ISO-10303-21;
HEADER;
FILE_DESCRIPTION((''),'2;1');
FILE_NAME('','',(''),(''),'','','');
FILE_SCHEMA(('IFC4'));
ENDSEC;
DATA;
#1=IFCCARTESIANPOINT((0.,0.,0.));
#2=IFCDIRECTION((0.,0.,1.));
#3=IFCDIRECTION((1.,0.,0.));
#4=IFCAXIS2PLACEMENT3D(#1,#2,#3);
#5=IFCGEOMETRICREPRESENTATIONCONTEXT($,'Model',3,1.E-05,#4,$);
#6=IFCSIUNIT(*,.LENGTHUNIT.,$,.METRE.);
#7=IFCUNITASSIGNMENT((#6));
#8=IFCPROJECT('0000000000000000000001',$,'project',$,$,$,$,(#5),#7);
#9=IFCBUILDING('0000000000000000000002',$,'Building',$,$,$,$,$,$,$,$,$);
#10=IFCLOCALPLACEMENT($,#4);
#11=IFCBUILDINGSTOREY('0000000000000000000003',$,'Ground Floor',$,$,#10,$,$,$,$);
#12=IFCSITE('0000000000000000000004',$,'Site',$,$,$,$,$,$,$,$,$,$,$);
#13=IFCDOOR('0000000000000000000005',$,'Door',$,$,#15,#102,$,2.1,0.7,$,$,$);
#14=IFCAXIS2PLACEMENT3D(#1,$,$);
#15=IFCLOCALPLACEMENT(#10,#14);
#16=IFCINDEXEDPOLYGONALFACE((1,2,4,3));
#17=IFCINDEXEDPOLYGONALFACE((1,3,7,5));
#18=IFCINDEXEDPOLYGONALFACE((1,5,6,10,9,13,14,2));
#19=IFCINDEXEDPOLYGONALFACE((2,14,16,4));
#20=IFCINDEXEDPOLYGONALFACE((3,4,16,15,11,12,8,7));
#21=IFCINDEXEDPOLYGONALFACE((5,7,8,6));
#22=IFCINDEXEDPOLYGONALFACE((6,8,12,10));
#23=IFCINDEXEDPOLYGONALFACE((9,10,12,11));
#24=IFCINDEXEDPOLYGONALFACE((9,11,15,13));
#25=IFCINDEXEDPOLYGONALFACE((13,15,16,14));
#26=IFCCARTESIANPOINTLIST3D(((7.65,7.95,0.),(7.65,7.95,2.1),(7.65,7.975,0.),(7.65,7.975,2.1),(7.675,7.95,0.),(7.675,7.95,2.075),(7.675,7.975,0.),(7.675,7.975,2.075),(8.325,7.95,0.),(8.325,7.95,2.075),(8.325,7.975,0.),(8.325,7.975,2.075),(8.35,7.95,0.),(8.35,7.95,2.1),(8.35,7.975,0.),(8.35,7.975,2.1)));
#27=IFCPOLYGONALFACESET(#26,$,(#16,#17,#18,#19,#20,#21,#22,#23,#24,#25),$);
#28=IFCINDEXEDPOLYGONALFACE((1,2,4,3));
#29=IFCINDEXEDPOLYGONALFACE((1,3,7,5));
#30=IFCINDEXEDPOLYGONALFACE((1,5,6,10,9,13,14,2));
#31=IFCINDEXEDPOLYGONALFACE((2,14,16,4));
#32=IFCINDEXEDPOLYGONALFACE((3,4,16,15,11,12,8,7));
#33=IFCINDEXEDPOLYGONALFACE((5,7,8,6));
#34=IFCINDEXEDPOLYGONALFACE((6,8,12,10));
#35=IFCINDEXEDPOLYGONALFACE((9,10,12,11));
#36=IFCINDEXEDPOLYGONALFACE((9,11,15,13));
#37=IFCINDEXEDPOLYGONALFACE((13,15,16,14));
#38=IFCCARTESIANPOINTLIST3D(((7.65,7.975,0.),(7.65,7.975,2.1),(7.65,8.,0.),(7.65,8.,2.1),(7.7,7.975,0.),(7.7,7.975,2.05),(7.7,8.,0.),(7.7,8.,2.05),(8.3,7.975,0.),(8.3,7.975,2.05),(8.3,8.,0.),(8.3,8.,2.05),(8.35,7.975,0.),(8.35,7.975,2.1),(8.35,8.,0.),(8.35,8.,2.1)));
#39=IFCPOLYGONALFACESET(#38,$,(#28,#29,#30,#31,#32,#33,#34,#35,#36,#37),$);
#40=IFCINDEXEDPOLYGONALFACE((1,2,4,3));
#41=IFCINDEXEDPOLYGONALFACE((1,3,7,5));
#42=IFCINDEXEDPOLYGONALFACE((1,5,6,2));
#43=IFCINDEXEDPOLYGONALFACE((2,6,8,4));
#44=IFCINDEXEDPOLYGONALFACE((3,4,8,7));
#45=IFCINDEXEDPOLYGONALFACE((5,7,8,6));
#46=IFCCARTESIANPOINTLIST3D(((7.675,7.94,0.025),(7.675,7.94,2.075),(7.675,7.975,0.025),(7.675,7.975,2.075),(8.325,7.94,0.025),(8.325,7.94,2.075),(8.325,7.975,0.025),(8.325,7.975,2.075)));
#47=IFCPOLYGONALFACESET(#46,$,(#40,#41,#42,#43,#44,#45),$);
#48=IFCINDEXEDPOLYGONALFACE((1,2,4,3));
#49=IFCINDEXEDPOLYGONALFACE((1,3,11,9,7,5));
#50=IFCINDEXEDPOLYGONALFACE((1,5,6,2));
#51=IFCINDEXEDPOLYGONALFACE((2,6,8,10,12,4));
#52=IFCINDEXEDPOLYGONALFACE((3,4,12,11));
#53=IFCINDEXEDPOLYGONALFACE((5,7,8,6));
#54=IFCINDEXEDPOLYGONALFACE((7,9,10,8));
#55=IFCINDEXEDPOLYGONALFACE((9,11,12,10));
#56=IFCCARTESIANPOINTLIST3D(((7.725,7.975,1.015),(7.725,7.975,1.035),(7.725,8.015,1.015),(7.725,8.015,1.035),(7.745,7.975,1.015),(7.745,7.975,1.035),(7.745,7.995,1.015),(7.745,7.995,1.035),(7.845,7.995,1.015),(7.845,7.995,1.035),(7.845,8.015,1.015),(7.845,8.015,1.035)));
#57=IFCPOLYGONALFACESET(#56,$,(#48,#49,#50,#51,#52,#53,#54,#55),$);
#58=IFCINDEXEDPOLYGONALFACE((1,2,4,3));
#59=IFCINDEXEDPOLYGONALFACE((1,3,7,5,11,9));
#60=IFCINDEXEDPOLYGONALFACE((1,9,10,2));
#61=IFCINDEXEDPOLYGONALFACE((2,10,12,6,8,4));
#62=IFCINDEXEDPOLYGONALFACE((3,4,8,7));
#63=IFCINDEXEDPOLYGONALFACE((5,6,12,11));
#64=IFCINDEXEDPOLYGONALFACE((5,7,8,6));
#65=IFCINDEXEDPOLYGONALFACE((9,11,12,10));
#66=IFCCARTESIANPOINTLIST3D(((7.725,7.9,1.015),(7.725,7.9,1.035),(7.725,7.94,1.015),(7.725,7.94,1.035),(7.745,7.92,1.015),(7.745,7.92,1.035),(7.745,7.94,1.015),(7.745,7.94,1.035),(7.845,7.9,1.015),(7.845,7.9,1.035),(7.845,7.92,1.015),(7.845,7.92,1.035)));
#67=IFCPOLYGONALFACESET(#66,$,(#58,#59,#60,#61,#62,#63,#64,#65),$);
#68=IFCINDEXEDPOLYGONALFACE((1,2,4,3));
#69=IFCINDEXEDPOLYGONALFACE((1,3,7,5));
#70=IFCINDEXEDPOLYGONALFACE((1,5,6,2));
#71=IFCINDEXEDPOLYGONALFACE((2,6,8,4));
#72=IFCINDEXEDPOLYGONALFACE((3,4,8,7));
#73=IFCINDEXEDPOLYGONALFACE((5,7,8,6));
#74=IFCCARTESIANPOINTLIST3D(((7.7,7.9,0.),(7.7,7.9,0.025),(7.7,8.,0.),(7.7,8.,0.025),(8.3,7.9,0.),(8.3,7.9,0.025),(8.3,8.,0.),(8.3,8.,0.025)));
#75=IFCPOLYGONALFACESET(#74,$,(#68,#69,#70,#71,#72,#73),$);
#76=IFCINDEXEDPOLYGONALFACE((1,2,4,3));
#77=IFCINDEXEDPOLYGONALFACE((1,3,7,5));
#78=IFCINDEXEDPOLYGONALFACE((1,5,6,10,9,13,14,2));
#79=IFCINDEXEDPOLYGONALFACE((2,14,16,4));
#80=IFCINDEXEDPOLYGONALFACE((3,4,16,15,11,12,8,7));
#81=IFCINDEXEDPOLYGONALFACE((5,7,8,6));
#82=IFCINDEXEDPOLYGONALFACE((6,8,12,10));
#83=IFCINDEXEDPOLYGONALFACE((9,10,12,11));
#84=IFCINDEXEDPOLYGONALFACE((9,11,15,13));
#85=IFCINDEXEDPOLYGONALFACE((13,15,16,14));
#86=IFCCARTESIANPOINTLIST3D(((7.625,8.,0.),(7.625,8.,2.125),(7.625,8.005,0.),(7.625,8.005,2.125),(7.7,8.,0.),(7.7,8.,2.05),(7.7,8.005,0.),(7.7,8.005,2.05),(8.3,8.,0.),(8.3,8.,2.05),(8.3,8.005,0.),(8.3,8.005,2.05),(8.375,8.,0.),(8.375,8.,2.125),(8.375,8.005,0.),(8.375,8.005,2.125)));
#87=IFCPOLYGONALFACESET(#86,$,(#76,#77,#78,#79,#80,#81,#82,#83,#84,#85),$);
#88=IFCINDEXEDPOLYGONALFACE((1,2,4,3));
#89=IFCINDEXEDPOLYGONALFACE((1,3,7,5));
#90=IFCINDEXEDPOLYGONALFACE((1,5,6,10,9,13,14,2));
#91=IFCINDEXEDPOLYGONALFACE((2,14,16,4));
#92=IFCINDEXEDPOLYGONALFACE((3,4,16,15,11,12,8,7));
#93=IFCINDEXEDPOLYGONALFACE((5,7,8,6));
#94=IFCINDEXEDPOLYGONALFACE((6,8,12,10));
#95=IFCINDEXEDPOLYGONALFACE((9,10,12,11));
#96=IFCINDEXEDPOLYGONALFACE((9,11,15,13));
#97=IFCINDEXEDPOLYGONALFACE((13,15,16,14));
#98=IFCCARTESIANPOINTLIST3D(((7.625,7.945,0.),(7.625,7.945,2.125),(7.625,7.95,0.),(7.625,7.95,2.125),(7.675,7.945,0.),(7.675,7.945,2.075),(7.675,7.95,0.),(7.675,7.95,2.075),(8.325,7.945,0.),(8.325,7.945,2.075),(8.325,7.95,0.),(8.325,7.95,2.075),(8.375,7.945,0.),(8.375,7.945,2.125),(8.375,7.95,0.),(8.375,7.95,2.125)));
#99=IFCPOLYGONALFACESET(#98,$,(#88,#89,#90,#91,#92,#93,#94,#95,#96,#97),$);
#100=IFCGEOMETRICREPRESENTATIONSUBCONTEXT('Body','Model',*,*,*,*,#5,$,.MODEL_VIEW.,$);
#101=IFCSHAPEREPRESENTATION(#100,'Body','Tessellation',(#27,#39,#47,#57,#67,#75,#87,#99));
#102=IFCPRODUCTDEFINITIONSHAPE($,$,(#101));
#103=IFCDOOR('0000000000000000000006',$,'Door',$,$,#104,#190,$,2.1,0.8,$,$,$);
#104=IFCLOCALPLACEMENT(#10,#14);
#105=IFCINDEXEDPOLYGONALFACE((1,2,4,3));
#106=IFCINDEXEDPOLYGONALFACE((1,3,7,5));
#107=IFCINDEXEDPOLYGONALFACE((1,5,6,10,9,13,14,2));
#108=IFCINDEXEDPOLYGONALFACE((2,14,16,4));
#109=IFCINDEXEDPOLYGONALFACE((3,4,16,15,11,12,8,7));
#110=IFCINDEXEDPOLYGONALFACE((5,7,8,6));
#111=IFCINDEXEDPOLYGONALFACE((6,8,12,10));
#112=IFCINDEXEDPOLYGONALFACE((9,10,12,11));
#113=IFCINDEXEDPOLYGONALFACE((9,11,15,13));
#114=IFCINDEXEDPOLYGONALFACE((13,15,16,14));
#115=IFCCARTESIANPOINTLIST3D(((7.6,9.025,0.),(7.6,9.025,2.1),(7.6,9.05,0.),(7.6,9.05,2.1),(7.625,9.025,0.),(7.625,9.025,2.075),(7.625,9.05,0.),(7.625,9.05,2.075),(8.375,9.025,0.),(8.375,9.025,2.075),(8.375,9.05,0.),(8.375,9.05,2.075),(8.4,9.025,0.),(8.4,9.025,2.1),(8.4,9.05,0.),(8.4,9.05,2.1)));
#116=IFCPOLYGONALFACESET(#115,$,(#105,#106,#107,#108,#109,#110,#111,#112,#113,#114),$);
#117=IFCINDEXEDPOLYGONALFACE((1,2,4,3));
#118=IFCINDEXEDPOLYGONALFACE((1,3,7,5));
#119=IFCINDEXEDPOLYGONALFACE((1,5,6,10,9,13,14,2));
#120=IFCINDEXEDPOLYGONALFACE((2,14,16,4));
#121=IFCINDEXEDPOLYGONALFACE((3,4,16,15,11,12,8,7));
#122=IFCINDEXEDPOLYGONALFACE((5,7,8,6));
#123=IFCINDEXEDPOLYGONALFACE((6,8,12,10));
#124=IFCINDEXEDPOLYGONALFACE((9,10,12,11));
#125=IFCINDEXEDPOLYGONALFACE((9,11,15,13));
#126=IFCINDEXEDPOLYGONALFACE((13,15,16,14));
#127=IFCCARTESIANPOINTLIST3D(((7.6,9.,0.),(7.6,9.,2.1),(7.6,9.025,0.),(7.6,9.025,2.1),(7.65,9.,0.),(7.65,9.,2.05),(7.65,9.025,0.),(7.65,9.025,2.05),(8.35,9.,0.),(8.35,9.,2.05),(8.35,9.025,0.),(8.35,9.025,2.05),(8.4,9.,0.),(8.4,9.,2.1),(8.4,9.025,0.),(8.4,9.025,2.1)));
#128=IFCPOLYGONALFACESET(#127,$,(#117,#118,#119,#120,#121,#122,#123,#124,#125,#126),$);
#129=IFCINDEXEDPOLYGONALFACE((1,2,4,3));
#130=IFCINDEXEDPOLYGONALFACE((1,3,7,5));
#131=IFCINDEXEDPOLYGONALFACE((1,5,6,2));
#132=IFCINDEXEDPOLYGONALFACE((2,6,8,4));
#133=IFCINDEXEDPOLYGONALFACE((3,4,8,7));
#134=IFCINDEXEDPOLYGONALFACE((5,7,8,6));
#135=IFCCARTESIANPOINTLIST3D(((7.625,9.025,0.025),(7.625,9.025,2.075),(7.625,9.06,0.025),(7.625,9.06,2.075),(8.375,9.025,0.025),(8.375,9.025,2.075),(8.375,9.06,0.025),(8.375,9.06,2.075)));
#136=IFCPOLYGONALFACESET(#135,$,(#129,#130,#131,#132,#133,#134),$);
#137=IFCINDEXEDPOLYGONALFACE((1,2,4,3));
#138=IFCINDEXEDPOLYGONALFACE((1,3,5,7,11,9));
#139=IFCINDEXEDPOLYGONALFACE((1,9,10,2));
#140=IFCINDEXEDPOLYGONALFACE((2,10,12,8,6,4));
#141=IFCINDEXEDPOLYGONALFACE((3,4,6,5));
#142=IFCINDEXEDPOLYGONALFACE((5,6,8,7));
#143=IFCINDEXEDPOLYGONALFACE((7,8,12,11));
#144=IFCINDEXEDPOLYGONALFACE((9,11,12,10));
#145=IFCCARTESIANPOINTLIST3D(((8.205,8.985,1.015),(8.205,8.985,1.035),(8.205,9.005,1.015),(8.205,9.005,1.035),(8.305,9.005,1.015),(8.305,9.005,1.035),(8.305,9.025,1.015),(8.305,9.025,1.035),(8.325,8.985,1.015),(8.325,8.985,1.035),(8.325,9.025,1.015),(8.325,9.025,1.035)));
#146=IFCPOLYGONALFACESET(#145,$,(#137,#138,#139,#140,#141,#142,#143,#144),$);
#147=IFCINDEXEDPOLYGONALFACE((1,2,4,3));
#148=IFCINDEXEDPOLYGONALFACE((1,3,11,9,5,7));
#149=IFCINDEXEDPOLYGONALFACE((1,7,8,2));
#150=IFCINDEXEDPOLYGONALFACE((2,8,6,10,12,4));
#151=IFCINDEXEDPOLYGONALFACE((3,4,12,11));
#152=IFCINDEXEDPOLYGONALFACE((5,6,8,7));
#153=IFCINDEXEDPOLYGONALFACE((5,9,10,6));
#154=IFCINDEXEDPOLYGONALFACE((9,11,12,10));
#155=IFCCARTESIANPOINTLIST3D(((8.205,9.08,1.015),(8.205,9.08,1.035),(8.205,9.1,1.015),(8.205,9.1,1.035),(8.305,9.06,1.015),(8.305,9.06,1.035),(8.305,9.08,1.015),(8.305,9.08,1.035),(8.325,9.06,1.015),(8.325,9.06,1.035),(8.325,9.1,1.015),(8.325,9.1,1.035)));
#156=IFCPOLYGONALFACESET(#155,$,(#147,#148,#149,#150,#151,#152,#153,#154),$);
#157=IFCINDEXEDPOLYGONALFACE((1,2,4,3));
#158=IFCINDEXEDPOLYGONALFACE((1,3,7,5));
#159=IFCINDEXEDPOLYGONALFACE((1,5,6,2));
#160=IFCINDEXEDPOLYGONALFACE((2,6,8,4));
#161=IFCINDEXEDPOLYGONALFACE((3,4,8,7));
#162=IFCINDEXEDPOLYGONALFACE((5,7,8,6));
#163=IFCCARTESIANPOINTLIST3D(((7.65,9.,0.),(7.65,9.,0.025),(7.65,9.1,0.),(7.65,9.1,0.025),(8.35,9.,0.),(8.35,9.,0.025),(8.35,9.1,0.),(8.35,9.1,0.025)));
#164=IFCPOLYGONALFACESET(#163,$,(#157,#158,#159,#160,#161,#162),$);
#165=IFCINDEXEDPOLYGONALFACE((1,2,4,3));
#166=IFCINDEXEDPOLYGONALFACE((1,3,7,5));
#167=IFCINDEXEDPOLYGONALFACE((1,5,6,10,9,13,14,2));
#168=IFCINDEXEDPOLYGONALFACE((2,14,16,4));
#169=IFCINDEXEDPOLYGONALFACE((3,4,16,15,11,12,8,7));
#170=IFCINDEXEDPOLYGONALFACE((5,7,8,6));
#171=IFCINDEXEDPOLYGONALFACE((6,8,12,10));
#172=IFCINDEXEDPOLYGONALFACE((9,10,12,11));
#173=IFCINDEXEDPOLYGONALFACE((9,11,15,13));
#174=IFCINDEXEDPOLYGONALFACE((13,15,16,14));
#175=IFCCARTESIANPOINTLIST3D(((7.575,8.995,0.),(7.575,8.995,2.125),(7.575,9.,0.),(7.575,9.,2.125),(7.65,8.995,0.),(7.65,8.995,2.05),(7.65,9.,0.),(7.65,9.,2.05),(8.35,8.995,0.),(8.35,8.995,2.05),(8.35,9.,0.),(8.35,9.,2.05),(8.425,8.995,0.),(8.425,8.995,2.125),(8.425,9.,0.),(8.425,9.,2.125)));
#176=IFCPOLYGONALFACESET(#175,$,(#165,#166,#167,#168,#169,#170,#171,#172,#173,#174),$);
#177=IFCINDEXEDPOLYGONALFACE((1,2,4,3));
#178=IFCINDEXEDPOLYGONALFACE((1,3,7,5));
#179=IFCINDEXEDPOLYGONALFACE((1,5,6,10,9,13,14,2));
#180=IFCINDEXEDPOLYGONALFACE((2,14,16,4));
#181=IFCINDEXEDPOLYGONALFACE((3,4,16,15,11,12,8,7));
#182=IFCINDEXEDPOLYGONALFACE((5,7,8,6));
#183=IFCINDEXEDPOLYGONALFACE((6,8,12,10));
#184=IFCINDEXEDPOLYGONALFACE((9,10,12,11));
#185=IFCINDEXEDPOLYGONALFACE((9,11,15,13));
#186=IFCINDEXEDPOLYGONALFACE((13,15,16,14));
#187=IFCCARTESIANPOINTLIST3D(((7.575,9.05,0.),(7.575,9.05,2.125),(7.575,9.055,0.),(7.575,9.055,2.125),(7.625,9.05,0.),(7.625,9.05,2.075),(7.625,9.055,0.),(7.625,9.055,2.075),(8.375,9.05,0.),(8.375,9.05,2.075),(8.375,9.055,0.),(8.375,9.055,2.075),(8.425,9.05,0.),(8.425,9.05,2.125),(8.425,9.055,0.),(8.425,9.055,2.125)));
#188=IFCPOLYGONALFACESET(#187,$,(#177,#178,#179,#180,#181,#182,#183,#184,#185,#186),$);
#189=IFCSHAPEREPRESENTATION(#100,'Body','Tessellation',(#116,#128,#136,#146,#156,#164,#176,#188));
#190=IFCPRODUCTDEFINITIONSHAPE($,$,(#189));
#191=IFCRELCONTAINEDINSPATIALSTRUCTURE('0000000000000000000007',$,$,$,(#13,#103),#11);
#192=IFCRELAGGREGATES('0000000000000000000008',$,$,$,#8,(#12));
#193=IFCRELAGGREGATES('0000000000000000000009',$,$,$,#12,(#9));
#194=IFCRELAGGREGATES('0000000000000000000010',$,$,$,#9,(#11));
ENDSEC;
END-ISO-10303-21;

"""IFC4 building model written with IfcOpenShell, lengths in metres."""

from ifc_helpers import new_model, si_unit, frame, origin_with_axes, place, context, subcontext, project, spatial, line, indexed_curve, outline, extrude, element, save


model = new_model("IFC4")

# Units and contexts
model_context = context("Model", 3, precision=1e-05, world=origin_with_axes())
body_context = subcontext(model_context, "Body", "Model", "MODEL_VIEW")
ifc_project = project(units=[si_unit("LENGTHUNIT", "METRE")], contexts=[model_context])

# Site, building, storey
site = spatial("IfcSite", under=ifc_project, Name="Site")
building = spatial("IfcBuilding", under=site, Name="Building")
storey_placement = place(None, origin_with_axes())
storey = spatial("IfcBuildingStorey", under=building, at=storey_placement, Name="Ground Floor")

# Doors
door_1_placement = place(storey_placement, frame((8.35, 8.0, 0.0), z_axis=(0.0, 0.0, 1.0), x_axis=(-1.0, 0.0, 0.0)))
element("IfcDoor", 1, at=door_1_placement, inside=storey, Name="Door", OverallHeight=2.1, OverallWidth=0.7, context=body_context, shape_type="SweptSolid", body=[
    extrude(outline(indexed_curve([(0.0, 0.0), (0.0, 2.1), (0.7, 2.1), (0.7, 0.0), (0.675, 0.0), (0.675, 2.075), (0.025, 2.075), (0.025, 0.0)], segments=[line(1, 2, 3, 4, 5, 6, 7, 8, 1)])), frame((0.0, 0.025, 0.0), z_axis=(0.0, -1.0, 0.0), x_axis=(1.0, 0.0, 0.0)), (0.0, 0.0, -1.0), 0.025),
    extrude(outline(indexed_curve([(0.0, 0.0), (0.0, 2.1), (0.7, 2.1), (0.7, 0.0), (0.65, 0.0), (0.65, 2.05), (0.05, 2.05), (0.05, 0.0)], segments=[line(1, 2, 3, 4, 5, 6, 7, 8, 1)])), frame((0.0, 0.0, 0.0), z_axis=(0.0, -1.0, 0.0), x_axis=(1.0, 0.0, 0.0)), (0.0, 0.0, -1.0), 0.025),
    extrude(outline(indexed_curve([(0.0, 0.0), (0.65, 0.0), (0.65, 0.035), (0.0, 0.035)], segments=[line(1, 2, 3, 4, 1)])), frame((0.025, 0.025, 0.025), z_axis=(0.0, 0.0, 1.0), x_axis=(1.0, 0.0, 0.0)), (0.0, 0.0, 1.0), 2.05),
    extrude(outline(indexed_curve([(0.0, 0.0), (0.0, -0.04), (-0.12, -0.04), (-0.12, -0.02), (-0.02, -0.02), (-0.02, 0.0)], segments=[line(1, 2, 3, 4, 5, 6, 1)])), frame((0.625, 0.025, 1.015), z_axis=(0.0, 0.0, 1.0), x_axis=(1.0, 0.0, 0.0)), (0.0, 0.0, 1.0), 0.02),
    extrude(outline(indexed_curve([(0.0, 0.0), (0.0, 0.04), (-0.12, 0.04), (-0.12, 0.02), (-0.02, 0.02), (-0.02, 0.0)], segments=[line(1, 2, 3, 4, 5, 6, 1)])), frame((0.625, 0.06, 1.015), z_axis=(0.0, 0.0, 1.0), x_axis=(1.0, 0.0, 0.0)), (0.0, 0.0, 1.0), 0.02),
    extrude(outline(indexed_curve([(0.0, 0.0), (0.6, 0.0), (0.6, 0.1), (0.0, 0.1)], segments=[line(1, 2, 3, 4, 1)])), frame((0.05, 0.0, 0.0), z_axis=(0.0, 0.0, 1.0), x_axis=(1.0, 0.0, 0.0)), (0.0, 0.0, 1.0), 0.025),
    extrude(outline(indexed_curve([(0.0, 0.0), (0.0, 2.125), (0.75, 2.125), (0.75, 0.0), (0.675, 0.0), (0.675, 2.05), (0.075, 2.05), (0.075, 0.0)], segments=[line(1, 2, 3, 4, 5, 6, 7, 8, 1)])), frame((-0.025, -0.005, 0.0), z_axis=(0.0, -1.0, 0.0), x_axis=(1.0, 0.0, 0.0)), (0.0, 0.0, -1.0), 0.005),
    extrude(outline(indexed_curve([(0.0, 0.0), (0.0, 2.125), (0.75, 2.125), (0.75, 0.0), (0.7, 0.0), (0.7, 2.075), (0.05, 2.075), (0.05, 0.0)], segments=[line(1, 2, 3, 4, 5, 6, 7, 8, 1)])), frame((-0.025, 0.05, 0.0), z_axis=(0.0, -1.0, 0.0), x_axis=(1.0, 0.0, 0.0)), (0.0, 0.0, -1.0), 0.005),
])
door_2_placement = place(storey_placement, frame((7.6, 9.0, 0.0), z_axis=(0.0, 0.0, 1.0), x_axis=(1.0, 0.0, 0.0)))
element("IfcDoor", 2, at=door_2_placement, inside=storey, Name="Door", OverallHeight=2.1, OverallWidth=0.8, context=body_context, shape_type="SweptSolid", body=[
    extrude(outline(indexed_curve([(0.0, 0.0), (0.0, 2.1), (0.8, 2.1), (0.8, 0.0), (0.775, 0.0), (0.775, 2.075), (0.025, 2.075), (0.025, 0.0)], segments=[line(1, 2, 3, 4, 5, 6, 7, 8, 1)])), frame((0.0, 0.025, 0.0), z_axis=(0.0, -1.0, 0.0), x_axis=(1.0, 0.0, 0.0)), (0.0, 0.0, -1.0), 0.025),
    extrude(outline(indexed_curve([(0.0, 0.0), (0.0, 2.1), (0.8, 2.1), (0.8, 0.0), (0.75, 0.0), (0.75, 2.05), (0.05, 2.05), (0.05, 0.0)], segments=[line(1, 2, 3, 4, 5, 6, 7, 8, 1)])), frame((0.0, 0.0, 0.0), z_axis=(0.0, -1.0, 0.0), x_axis=(1.0, 0.0, 0.0)), (0.0, 0.0, -1.0), 0.025),
    extrude(outline(indexed_curve([(0.0, 0.0), (0.75, 0.0), (0.75, 0.035), (0.0, 0.035)], segments=[line(1, 2, 3, 4, 1)])), frame((0.025, 0.025, 0.025), z_axis=(0.0, 0.0, 1.0), x_axis=(1.0, 0.0, 0.0)), (0.0, 0.0, 1.0), 2.05),
    extrude(outline(indexed_curve([(0.0, 0.0), (0.0, -0.04), (-0.12, -0.04), (-0.12, -0.02), (-0.02, -0.02), (-0.02, 0.0)], segments=[line(1, 2, 3, 4, 5, 6, 1)])), frame((0.725, 0.025, 1.015), z_axis=(0.0, 0.0, 1.0), x_axis=(1.0, 0.0, 0.0)), (0.0, 0.0, 1.0), 0.02),
    extrude(outline(indexed_curve([(0.0, 0.0), (0.0, 0.04), (-0.12, 0.04), (-0.12, 0.02), (-0.02, 0.02), (-0.02, 0.0)], segments=[line(1, 2, 3, 4, 5, 6, 1)])), frame((0.725, 0.06, 1.015), z_axis=(0.0, 0.0, 1.0), x_axis=(1.0, 0.0, 0.0)), (0.0, 0.0, 1.0), 0.02),
    extrude(outline(indexed_curve([(0.0, 0.0), (0.7, 0.0), (0.7, 0.1), (0.0, 0.1)], segments=[line(1, 2, 3, 4, 1)])), frame((0.05, 0.0, 0.0), z_axis=(0.0, 0.0, 1.0), x_axis=(1.0, 0.0, 0.0)), (0.0, 0.0, 1.0), 0.025),
    extrude(outline(indexed_curve([(0.0, 0.0), (0.0, 2.125), (0.85, 2.125), (0.85, 0.0), (0.775, 0.0), (0.775, 2.05), (0.075, 2.05), (0.075, 0.0)], segments=[line(1, 2, 3, 4, 5, 6, 7, 8, 1)])), frame((-0.025, -0.005, 0.0), z_axis=(0.0, -1.0, 0.0), x_axis=(1.0, 0.0, 0.0)), (0.0, 0.0, -1.0), 0.005),
    extrude(outline(indexed_curve([(0.0, 0.0), (0.0, 2.125), (0.85, 2.125), (0.85, 0.0), (0.8, 0.0), (0.8, 2.075), (0.05, 2.075), (0.05, 0.0)], segments=[line(1, 2, 3, 4, 5, 6, 7, 8, 1)])), frame((-0.025, 0.05, 0.0), z_axis=(0.0, -1.0, 0.0), x_axis=(1.0, 0.0, 0.0)), (0.0, 0.0, -1.0), 0.005),
])

save(model, "model.ifc")
